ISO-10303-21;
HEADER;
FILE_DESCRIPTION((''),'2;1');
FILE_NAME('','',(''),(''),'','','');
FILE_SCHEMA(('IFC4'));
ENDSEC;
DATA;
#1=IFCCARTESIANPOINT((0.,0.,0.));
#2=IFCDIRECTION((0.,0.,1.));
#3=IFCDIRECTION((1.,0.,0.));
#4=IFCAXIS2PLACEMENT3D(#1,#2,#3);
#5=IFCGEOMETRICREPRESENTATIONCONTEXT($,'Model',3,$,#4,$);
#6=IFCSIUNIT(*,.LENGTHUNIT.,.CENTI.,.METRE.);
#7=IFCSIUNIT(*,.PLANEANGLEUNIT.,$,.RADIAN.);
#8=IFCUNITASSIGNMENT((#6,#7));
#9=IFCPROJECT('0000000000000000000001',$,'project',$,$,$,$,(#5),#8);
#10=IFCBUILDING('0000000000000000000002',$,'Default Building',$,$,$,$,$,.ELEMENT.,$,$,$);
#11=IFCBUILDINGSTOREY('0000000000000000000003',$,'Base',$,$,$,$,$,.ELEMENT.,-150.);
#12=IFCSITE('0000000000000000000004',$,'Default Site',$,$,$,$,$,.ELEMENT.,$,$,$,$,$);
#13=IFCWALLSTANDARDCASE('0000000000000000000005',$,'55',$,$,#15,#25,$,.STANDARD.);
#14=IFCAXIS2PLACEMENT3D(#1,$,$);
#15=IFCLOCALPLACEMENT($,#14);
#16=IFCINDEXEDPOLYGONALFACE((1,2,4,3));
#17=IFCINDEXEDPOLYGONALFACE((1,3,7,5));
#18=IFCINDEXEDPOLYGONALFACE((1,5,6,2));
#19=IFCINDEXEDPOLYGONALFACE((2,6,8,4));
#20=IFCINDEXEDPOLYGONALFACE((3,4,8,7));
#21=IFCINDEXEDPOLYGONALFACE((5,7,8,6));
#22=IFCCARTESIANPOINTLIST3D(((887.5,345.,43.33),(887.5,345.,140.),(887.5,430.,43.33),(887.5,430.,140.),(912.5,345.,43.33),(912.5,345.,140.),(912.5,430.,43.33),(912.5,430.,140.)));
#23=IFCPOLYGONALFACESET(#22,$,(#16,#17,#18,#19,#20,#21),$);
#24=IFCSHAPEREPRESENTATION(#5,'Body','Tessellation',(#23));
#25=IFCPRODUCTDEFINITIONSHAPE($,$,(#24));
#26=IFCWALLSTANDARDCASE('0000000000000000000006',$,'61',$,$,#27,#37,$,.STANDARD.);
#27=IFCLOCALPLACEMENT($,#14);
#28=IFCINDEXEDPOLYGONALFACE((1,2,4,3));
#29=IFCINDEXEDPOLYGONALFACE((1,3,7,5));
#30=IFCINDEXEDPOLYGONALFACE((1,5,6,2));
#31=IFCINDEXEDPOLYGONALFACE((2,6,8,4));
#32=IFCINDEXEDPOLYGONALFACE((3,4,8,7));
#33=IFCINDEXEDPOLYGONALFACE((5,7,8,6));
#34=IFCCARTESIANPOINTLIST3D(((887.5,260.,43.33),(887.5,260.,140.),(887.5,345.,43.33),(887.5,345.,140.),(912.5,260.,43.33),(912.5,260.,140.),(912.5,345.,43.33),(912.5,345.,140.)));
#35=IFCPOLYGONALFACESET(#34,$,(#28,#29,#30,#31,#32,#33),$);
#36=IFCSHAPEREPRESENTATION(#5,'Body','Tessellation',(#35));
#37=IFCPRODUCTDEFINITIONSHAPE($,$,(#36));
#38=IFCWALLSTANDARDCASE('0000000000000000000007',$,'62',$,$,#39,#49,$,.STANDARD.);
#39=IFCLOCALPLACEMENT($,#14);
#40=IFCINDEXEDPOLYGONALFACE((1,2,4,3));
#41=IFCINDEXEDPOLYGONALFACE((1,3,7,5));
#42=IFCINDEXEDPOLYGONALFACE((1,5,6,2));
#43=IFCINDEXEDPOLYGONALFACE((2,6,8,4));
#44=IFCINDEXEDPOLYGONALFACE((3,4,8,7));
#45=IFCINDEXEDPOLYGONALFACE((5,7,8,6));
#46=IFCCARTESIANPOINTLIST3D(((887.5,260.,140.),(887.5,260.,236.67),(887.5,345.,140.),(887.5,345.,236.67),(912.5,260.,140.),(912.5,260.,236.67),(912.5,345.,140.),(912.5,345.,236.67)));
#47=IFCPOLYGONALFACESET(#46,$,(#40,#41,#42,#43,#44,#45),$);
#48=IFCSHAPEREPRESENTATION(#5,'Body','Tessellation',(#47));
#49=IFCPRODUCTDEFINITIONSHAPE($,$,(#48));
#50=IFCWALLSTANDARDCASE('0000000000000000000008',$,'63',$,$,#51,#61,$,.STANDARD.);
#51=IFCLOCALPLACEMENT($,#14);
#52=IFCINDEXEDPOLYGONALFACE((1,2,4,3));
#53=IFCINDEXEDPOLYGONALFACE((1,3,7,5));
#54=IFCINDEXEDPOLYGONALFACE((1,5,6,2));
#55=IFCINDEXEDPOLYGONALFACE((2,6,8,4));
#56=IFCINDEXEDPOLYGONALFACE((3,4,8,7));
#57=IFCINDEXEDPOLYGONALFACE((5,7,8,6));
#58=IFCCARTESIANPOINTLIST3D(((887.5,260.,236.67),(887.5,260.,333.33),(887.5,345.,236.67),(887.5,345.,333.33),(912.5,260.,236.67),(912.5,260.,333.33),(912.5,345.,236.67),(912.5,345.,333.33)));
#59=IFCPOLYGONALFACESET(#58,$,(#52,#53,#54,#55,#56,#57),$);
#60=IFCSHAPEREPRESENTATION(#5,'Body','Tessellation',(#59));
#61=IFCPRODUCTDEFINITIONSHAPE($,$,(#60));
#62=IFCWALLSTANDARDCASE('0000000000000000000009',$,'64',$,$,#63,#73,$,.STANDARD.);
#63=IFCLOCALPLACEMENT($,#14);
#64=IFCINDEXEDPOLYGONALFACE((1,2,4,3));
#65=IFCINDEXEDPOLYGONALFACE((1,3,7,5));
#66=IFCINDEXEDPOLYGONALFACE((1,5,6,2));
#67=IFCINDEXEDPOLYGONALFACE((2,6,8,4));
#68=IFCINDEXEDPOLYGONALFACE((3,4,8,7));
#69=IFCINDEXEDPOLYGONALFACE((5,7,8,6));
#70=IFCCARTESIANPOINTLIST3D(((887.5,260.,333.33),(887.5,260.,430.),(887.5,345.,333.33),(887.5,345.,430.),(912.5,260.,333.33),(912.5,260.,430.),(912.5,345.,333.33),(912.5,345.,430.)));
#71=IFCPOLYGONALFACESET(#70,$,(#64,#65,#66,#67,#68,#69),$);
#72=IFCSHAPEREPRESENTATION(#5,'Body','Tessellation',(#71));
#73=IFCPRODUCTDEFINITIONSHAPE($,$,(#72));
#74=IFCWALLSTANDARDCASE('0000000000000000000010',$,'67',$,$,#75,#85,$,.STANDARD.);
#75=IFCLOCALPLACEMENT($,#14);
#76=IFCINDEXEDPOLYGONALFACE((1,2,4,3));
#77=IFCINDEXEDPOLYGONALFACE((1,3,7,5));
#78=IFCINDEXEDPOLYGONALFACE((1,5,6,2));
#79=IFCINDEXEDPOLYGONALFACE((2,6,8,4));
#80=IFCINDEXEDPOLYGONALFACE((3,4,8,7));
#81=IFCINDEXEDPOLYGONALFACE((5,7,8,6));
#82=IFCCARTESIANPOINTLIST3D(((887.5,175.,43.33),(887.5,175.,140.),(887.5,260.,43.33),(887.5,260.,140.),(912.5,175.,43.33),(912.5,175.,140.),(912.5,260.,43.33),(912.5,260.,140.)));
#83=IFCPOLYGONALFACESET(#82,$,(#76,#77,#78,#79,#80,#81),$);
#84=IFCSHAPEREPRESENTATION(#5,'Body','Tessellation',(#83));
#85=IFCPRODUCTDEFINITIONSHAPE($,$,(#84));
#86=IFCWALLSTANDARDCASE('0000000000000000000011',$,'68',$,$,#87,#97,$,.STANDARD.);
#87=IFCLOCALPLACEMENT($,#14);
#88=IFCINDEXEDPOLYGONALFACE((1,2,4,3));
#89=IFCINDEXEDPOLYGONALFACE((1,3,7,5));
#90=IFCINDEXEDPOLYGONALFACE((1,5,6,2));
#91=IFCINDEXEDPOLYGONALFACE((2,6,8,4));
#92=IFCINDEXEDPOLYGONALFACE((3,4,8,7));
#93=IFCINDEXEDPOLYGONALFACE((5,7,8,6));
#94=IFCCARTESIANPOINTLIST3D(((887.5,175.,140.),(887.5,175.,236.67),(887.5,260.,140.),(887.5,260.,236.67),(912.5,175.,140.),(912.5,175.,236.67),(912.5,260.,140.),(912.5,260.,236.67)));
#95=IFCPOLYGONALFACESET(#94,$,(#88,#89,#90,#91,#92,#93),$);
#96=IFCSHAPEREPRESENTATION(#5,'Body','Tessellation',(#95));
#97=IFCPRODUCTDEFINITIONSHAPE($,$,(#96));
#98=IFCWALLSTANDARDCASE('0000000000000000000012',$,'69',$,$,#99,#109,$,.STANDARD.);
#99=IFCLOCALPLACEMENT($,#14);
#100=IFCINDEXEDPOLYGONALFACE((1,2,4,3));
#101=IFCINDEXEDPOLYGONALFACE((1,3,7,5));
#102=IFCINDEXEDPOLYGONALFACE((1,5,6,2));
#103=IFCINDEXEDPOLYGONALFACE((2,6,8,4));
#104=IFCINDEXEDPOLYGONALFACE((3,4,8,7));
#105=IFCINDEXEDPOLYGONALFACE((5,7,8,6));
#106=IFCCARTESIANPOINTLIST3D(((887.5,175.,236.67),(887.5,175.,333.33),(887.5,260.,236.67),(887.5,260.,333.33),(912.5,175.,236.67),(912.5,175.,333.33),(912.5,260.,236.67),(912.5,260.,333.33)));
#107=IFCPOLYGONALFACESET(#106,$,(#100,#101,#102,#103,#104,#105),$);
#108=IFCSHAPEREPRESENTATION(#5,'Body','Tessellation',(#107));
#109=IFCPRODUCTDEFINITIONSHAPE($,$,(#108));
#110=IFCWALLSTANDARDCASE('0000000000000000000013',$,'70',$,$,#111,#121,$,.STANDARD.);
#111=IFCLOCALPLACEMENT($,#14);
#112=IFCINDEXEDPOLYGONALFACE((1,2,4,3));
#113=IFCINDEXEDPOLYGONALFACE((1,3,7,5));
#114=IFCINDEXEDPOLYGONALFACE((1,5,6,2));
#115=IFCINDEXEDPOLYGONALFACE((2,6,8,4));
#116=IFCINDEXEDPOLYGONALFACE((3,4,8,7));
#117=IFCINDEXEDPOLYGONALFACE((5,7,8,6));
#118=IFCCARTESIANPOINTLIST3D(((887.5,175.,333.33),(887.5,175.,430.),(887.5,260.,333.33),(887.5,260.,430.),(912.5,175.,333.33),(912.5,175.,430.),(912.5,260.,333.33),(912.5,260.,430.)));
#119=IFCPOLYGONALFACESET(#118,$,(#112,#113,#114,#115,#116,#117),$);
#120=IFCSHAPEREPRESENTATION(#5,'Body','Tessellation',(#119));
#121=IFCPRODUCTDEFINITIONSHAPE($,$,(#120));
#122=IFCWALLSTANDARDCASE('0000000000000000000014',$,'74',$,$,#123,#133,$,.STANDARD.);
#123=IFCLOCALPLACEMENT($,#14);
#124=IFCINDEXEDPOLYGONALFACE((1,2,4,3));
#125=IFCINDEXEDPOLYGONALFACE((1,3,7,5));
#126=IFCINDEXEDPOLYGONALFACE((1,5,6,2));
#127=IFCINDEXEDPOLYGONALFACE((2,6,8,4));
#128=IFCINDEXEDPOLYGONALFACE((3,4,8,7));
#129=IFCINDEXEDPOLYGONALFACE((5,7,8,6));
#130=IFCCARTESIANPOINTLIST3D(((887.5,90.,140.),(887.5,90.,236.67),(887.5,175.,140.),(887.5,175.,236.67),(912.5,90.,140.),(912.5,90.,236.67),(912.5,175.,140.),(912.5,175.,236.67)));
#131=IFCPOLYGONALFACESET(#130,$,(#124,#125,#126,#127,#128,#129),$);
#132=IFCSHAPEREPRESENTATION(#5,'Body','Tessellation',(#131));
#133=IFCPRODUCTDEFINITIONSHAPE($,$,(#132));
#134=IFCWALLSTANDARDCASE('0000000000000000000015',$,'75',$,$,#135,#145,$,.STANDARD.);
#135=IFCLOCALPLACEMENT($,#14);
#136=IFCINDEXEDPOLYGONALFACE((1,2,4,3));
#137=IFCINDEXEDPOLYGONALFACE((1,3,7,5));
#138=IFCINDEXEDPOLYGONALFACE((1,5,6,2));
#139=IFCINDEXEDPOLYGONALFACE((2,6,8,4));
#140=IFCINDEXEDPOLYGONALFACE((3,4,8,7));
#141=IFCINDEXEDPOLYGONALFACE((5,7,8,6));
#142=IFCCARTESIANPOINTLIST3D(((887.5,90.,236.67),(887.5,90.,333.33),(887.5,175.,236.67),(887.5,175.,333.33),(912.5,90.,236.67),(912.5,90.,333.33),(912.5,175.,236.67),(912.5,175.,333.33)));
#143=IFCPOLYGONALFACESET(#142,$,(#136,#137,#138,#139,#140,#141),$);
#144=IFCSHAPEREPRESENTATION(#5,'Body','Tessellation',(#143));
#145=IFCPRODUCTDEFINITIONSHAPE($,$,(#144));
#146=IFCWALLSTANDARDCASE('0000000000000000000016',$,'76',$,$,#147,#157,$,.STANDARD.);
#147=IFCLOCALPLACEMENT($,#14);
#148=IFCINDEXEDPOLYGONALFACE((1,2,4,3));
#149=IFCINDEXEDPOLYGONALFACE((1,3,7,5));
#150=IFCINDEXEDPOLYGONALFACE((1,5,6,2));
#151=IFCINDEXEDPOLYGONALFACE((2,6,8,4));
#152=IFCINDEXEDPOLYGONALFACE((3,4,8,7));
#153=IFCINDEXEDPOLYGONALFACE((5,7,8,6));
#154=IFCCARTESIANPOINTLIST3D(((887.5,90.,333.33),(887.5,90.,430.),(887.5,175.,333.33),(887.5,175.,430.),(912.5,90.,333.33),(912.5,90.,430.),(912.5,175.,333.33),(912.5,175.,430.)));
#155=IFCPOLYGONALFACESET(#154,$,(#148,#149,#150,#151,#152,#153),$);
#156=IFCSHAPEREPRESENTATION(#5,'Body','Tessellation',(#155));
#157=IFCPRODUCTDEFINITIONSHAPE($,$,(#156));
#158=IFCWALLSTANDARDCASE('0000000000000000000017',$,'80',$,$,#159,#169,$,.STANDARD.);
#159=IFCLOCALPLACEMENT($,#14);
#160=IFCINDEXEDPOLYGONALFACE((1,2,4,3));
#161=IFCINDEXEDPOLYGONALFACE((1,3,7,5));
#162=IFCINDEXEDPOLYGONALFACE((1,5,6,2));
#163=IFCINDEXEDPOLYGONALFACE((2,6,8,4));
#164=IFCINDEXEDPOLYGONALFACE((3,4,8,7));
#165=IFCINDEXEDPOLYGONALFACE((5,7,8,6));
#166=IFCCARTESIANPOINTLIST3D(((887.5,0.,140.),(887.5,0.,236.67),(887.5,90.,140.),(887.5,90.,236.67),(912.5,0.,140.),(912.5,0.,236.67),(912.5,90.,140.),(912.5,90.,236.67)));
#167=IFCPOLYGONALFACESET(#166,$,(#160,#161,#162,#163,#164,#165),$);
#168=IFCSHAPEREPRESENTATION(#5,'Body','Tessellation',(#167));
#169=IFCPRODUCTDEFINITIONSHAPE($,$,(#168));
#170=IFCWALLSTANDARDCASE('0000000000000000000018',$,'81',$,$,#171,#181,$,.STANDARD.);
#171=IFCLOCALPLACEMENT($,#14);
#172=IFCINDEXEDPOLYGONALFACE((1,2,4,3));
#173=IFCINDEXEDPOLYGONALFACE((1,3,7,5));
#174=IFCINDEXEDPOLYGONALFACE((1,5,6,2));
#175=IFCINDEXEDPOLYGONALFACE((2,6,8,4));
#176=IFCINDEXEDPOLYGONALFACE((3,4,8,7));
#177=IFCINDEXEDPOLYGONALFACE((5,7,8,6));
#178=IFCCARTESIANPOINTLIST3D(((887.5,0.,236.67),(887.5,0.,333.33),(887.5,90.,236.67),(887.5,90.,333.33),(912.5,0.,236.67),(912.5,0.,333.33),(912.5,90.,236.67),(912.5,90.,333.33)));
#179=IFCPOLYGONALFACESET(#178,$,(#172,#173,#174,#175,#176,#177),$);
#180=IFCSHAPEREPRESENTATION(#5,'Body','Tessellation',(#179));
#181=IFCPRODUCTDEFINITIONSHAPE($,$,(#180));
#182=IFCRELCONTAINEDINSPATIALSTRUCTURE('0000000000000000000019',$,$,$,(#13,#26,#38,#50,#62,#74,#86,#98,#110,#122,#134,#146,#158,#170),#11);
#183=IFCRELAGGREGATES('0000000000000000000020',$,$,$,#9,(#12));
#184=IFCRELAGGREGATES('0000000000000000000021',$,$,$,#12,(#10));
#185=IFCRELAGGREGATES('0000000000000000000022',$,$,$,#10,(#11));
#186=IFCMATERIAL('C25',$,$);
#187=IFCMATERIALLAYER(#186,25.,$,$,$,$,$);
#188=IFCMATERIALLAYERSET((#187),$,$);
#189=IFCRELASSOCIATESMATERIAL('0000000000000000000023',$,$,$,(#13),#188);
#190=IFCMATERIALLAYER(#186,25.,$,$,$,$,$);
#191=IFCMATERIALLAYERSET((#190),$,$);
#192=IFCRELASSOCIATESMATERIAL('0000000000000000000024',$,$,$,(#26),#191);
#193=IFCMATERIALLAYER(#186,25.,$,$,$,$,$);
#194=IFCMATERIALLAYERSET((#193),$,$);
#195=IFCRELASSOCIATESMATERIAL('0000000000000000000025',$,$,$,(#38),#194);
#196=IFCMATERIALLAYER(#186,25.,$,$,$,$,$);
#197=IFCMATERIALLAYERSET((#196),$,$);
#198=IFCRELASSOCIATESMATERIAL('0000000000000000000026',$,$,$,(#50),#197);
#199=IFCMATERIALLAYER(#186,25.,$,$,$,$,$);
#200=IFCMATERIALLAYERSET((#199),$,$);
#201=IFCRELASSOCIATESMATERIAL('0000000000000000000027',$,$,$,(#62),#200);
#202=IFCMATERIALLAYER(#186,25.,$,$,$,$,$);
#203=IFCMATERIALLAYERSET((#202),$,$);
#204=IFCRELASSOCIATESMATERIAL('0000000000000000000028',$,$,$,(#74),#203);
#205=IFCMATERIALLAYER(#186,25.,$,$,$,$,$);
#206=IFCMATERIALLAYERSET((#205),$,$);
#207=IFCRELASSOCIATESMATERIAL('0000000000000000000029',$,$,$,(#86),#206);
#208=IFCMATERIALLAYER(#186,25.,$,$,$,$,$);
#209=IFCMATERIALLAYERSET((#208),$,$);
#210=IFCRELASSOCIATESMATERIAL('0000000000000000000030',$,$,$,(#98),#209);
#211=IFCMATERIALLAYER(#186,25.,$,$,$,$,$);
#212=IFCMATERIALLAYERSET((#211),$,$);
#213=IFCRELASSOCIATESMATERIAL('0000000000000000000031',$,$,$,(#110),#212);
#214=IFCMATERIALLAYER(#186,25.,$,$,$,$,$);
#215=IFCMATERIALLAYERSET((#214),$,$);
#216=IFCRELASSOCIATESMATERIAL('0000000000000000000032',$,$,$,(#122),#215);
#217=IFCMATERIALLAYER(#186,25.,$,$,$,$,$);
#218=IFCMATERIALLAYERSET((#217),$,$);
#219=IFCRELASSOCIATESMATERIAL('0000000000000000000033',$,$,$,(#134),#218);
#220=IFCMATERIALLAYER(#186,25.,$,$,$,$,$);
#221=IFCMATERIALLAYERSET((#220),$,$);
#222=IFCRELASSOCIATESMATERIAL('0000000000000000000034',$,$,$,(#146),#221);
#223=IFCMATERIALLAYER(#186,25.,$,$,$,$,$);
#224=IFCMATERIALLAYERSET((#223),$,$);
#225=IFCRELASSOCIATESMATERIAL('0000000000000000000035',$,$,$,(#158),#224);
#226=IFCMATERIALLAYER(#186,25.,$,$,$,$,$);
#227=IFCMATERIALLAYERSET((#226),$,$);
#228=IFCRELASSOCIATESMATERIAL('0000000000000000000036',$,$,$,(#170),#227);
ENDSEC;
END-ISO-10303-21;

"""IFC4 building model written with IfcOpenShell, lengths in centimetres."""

from ifc_helpers import new_model, si_unit, frame, origin_with_axes, origin_2d_with_axis, place, context, project, spatial, rectangle, extrude, material, layer, layer_set, layer_usage, element, save


model = new_model("IFC4")

# Units and contexts
model_context = context("Model", 3, world=origin_with_axes())
ifc_project = project(units=[si_unit("LENGTHUNIT", "METRE", prefix="CENTI"), si_unit("PLANEANGLEUNIT", "RADIAN")], contexts=[model_context])

# Site, building, storey
site = spatial("IfcSite", under=ifc_project, Name="Default Site", CompositionType="ELEMENT")
building = spatial("IfcBuilding", under=site, Name="Default Building", CompositionType="ELEMENT")
storey = spatial("IfcBuildingStorey", under=building, Name="Base", CompositionType="ELEMENT", Elevation=-150.0)

# Walls
ifc_material = material(Name="C25")
ifc_layer_1 = layer(ifc_material, 25.0)
ifc_layer_set_1 = layer_set([ifc_layer_1])
ifc_layer_usage_1 = layer_usage(ifc_layer_set_1, "AXIS2", "POSITIVE", -25.0)
wall_1_placement = place(None, frame((900.0, 387.5, 43.33), z_axis=(0.0, 0.0, 1.0), x_axis=(0.0, -1.0, 0.0)))
element("IfcWallStandardCase", 1, at=wall_1_placement, inside=storey, material=ifc_layer_usage_1, Name="55", PredefinedType="STANDARD", context=model_context, shape_type="SweptSolid", body=[
    extrude(rectangle(XDim=85.0, YDim=25.0, at=origin_2d_with_axis()), origin_with_axes(), (0.0, 0.0, 1.0), 96.67),
])
ifc_layer_2 = layer(ifc_material, 25.0)
ifc_layer_set_2 = layer_set([ifc_layer_2])
ifc_layer_usage_2 = layer_usage(ifc_layer_set_2, "AXIS2", "POSITIVE", -25.0)
wall_2_placement = place(None, frame((900.0, 302.5, 43.33), z_axis=(0.0, 0.0, 1.0), x_axis=(0.0, -1.0, 0.0)))
element("IfcWallStandardCase", 2, at=wall_2_placement, inside=storey, material=ifc_layer_usage_2, Name="61", PredefinedType="STANDARD", context=model_context, shape_type="SweptSolid", body=[
    extrude(rectangle(XDim=85.0, YDim=25.0, at=origin_2d_with_axis()), origin_with_axes(), (0.0, 0.0, 1.0), 96.67),
])
ifc_layer_3 = layer(ifc_material, 25.0)
ifc_layer_set_3 = layer_set([ifc_layer_3])
ifc_layer_usage_3 = layer_usage(ifc_layer_set_3, "AXIS2", "POSITIVE", -25.0)
wall_3_placement = place(None, frame((900.0, 302.5, 140.0), z_axis=(0.0, 0.0, 1.0), x_axis=(0.0, -1.0, 0.0)))
element("IfcWallStandardCase", 3, at=wall_3_placement, inside=storey, material=ifc_layer_usage_3, Name="62", PredefinedType="STANDARD", context=model_context, shape_type="SweptSolid", body=[
    extrude(rectangle(XDim=85.0, YDim=25.0, at=origin_2d_with_axis()), origin_with_axes(), (0.0, 0.0, 1.0), 96.67),
])
ifc_layer_4 = layer(ifc_material, 25.0)
ifc_layer_set_4 = layer_set([ifc_layer_4])
ifc_layer_usage_4 = layer_usage(ifc_layer_set_4, "AXIS2", "POSITIVE", -25.0)
wall_4_placement = place(None, frame((900.0, 302.5, 236.67), z_axis=(0.0, 0.0, 1.0), x_axis=(0.0, -1.0, 0.0)))
element("IfcWallStandardCase", 4, at=wall_4_placement, inside=storey, material=ifc_layer_usage_4, Name="63", PredefinedType="STANDARD", context=model_context, shape_type="SweptSolid", body=[
    extrude(rectangle(XDim=85.0, YDim=25.0, at=origin_2d_with_axis()), origin_with_axes(), (0.0, 0.0, 1.0), 96.67),
])
ifc_layer_5 = layer(ifc_material, 25.0)
ifc_layer_set_5 = layer_set([ifc_layer_5])
ifc_layer_usage_5 = layer_usage(ifc_layer_set_5, "AXIS2", "POSITIVE", -25.0)
wall_5_placement = place(None, frame((900.0, 302.5, 333.33), z_axis=(0.0, 0.0, 1.0), x_axis=(0.0, -1.0, 0.0)))
element("IfcWallStandardCase", 5, at=wall_5_placement, inside=storey, material=ifc_layer_usage_5, Name="64", PredefinedType="STANDARD", context=model_context, shape_type="SweptSolid", body=[
    extrude(rectangle(XDim=85.0, YDim=25.0, at=origin_2d_with_axis()), origin_with_axes(), (0.0, 0.0, 1.0), 96.67),
])
ifc_layer_6 = layer(ifc_material, 25.0)
ifc_layer_set_6 = layer_set([ifc_layer_6])
ifc_layer_usage_6 = layer_usage(ifc_layer_set_6, "AXIS2", "POSITIVE", -25.0)
wall_6_placement = place(None, frame((900.0, 217.5, 43.33), z_axis=(0.0, 0.0, 1.0), x_axis=(0.0, -1.0, 0.0)))
element("IfcWallStandardCase", 6, at=wall_6_placement, inside=storey, material=ifc_layer_usage_6, Name="67", PredefinedType="STANDARD", context=model_context, shape_type="SweptSolid", body=[
    extrude(rectangle(XDim=85.0, YDim=25.0, at=origin_2d_with_axis()), origin_with_axes(), (0.0, 0.0, 1.0), 96.67),
])
ifc_layer_7 = layer(ifc_material, 25.0)
ifc_layer_set_7 = layer_set([ifc_layer_7])
ifc_layer_usage_7 = layer_usage(ifc_layer_set_7, "AXIS2", "POSITIVE", -25.0)
wall_7_placement = place(None, frame((900.0, 217.5, 140.0), z_axis=(0.0, 0.0, 1.0), x_axis=(0.0, -1.0, 0.0)))
element("IfcWallStandardCase", 7, at=wall_7_placement, inside=storey, material=ifc_layer_usage_7, Name="68", PredefinedType="STANDARD", context=model_context, shape_type="SweptSolid", body=[
    extrude(rectangle(XDim=85.0, YDim=25.0, at=origin_2d_with_axis()), origin_with_axes(), (0.0, 0.0, 1.0), 96.67),
])
ifc_layer_8 = layer(ifc_material, 25.0)
ifc_layer_set_8 = layer_set([ifc_layer_8])
ifc_layer_usage_8 = layer_usage(ifc_layer_set_8, "AXIS2", "POSITIVE", -25.0)
wall_8_placement = place(None, frame((900.0, 217.5, 236.67), z_axis=(0.0, 0.0, 1.0), x_axis=(0.0, -1.0, 0.0)))
element("IfcWallStandardCase", 8, at=wall_8_placement, inside=storey, material=ifc_layer_usage_8, Name="69", PredefinedType="STANDARD", context=model_context, shape_type="SweptSolid", body=[
    extrude(rectangle(XDim=85.0, YDim=25.0, at=origin_2d_with_axis()), origin_with_axes(), (0.0, 0.0, 1.0), 96.67),
])
ifc_layer_9 = layer(ifc_material, 25.0)
ifc_layer_set_9 = layer_set([ifc_layer_9])
ifc_layer_usage_9 = layer_usage(ifc_layer_set_9, "AXIS2", "POSITIVE", -25.0)
wall_9_placement = place(None, frame((900.0, 217.5, 333.33), z_axis=(0.0, 0.0, 1.0), x_axis=(0.0, -1.0, 0.0)))
element("IfcWallStandardCase", 9, at=wall_9_placement, inside=storey, material=ifc_layer_usage_9, Name="70", PredefinedType="STANDARD", context=model_context, shape_type="SweptSolid", body=[
    extrude(rectangle(XDim=85.0, YDim=25.0, at=origin_2d_with_axis()), origin_with_axes(), (0.0, 0.0, 1.0), 96.67),
])
ifc_layer_10 = layer(ifc_material, 25.0)
ifc_layer_set_10 = layer_set([ifc_layer_10])
ifc_layer_usage_10 = layer_usage(ifc_layer_set_10, "AXIS2", "POSITIVE", -25.0)
wall_10_placement = place(None, frame((900.0, 132.5, 140.0), z_axis=(0.0, 0.0, 1.0), x_axis=(0.0, -1.0, 0.0)))
element("IfcWallStandardCase", 10, at=wall_10_placement, inside=storey, material=ifc_layer_usage_10, Name="74", PredefinedType="STANDARD", context=model_context, shape_type="SweptSolid", body=[
    extrude(rectangle(XDim=85.0, YDim=25.0, at=origin_2d_with_axis()), origin_with_axes(), (0.0, 0.0, 1.0), 96.67),
])
ifc_layer_11 = layer(ifc_material, 25.0)
ifc_layer_set_11 = layer_set([ifc_layer_11])
ifc_layer_usage_11 = layer_usage(ifc_layer_set_11, "AXIS2", "POSITIVE", -25.0)
wall_11_placement = place(None, frame((900.0, 132.5, 236.67), z_axis=(0.0, 0.0, 1.0), x_axis=(0.0, -1.0, 0.0)))
element("IfcWallStandardCase", 11, at=wall_11_placement, inside=storey, material=ifc_layer_usage_11, Name="75", PredefinedType="STANDARD", context=model_context, shape_type="SweptSolid", body=[
    extrude(rectangle(XDim=85.0, YDim=25.0, at=origin_2d_with_axis()), origin_with_axes(), (0.0, 0.0, 1.0), 96.67),
])
ifc_layer_12 = layer(ifc_material, 25.0)
ifc_layer_set_12 = layer_set([ifc_layer_12])
ifc_layer_usage_12 = layer_usage(ifc_layer_set_12, "AXIS2", "POSITIVE", -25.0)
wall_12_placement = place(None, frame((900.0, 132.5, 333.33), z_axis=(0.0, 0.0, 1.0), x_axis=(0.0, -1.0, 0.0)))
element("IfcWallStandardCase", 12, at=wall_12_placement, inside=storey, material=ifc_layer_usage_12, Name="76", PredefinedType="STANDARD", context=model_context, shape_type="SweptSolid", body=[
    extrude(rectangle(XDim=85.0, YDim=25.0, at=origin_2d_with_axis()), origin_with_axes(), (0.0, 0.0, 1.0), 96.67),
])
ifc_layer_13 = layer(ifc_material, 25.0)
ifc_layer_set_13 = layer_set([ifc_layer_13])
ifc_layer_usage_13 = layer_usage(ifc_layer_set_13, "AXIS2", "POSITIVE", -25.0)
wall_13_placement = place(None, frame((900.0, 45.0, 140.0), z_axis=(0.0, 0.0, 1.0), x_axis=(0.0, -1.0, 0.0)))
element("IfcWallStandardCase", 13, at=wall_13_placement, inside=storey, material=ifc_layer_usage_13, Name="80", PredefinedType="STANDARD", context=model_context, shape_type="SweptSolid", body=[
    extrude(rectangle(XDim=90.0, YDim=25.0, at=origin_2d_with_axis()), origin_with_axes(), (0.0, 0.0, 1.0), 96.67),
])
ifc_layer_14 = layer(ifc_material, 25.0)
ifc_layer_set_14 = layer_set([ifc_layer_14])
ifc_layer_usage_14 = layer_usage(ifc_layer_set_14, "AXIS2", "POSITIVE", -25.0)
wall_14_placement = place(None, frame((900.0, 45.0, 236.67), z_axis=(0.0, 0.0, 1.0), x_axis=(0.0, -1.0, 0.0)))
element("IfcWallStandardCase", 14, at=wall_14_placement, inside=storey, material=ifc_layer_usage_14, Name="81", PredefinedType="STANDARD", context=model_context, shape_type="SweptSolid", body=[
    extrude(rectangle(XDim=90.0, YDim=25.0, at=origin_2d_with_axis()), origin_with_axes(), (0.0, 0.0, 1.0), 96.67),
])

save(model, "model.ifc")
